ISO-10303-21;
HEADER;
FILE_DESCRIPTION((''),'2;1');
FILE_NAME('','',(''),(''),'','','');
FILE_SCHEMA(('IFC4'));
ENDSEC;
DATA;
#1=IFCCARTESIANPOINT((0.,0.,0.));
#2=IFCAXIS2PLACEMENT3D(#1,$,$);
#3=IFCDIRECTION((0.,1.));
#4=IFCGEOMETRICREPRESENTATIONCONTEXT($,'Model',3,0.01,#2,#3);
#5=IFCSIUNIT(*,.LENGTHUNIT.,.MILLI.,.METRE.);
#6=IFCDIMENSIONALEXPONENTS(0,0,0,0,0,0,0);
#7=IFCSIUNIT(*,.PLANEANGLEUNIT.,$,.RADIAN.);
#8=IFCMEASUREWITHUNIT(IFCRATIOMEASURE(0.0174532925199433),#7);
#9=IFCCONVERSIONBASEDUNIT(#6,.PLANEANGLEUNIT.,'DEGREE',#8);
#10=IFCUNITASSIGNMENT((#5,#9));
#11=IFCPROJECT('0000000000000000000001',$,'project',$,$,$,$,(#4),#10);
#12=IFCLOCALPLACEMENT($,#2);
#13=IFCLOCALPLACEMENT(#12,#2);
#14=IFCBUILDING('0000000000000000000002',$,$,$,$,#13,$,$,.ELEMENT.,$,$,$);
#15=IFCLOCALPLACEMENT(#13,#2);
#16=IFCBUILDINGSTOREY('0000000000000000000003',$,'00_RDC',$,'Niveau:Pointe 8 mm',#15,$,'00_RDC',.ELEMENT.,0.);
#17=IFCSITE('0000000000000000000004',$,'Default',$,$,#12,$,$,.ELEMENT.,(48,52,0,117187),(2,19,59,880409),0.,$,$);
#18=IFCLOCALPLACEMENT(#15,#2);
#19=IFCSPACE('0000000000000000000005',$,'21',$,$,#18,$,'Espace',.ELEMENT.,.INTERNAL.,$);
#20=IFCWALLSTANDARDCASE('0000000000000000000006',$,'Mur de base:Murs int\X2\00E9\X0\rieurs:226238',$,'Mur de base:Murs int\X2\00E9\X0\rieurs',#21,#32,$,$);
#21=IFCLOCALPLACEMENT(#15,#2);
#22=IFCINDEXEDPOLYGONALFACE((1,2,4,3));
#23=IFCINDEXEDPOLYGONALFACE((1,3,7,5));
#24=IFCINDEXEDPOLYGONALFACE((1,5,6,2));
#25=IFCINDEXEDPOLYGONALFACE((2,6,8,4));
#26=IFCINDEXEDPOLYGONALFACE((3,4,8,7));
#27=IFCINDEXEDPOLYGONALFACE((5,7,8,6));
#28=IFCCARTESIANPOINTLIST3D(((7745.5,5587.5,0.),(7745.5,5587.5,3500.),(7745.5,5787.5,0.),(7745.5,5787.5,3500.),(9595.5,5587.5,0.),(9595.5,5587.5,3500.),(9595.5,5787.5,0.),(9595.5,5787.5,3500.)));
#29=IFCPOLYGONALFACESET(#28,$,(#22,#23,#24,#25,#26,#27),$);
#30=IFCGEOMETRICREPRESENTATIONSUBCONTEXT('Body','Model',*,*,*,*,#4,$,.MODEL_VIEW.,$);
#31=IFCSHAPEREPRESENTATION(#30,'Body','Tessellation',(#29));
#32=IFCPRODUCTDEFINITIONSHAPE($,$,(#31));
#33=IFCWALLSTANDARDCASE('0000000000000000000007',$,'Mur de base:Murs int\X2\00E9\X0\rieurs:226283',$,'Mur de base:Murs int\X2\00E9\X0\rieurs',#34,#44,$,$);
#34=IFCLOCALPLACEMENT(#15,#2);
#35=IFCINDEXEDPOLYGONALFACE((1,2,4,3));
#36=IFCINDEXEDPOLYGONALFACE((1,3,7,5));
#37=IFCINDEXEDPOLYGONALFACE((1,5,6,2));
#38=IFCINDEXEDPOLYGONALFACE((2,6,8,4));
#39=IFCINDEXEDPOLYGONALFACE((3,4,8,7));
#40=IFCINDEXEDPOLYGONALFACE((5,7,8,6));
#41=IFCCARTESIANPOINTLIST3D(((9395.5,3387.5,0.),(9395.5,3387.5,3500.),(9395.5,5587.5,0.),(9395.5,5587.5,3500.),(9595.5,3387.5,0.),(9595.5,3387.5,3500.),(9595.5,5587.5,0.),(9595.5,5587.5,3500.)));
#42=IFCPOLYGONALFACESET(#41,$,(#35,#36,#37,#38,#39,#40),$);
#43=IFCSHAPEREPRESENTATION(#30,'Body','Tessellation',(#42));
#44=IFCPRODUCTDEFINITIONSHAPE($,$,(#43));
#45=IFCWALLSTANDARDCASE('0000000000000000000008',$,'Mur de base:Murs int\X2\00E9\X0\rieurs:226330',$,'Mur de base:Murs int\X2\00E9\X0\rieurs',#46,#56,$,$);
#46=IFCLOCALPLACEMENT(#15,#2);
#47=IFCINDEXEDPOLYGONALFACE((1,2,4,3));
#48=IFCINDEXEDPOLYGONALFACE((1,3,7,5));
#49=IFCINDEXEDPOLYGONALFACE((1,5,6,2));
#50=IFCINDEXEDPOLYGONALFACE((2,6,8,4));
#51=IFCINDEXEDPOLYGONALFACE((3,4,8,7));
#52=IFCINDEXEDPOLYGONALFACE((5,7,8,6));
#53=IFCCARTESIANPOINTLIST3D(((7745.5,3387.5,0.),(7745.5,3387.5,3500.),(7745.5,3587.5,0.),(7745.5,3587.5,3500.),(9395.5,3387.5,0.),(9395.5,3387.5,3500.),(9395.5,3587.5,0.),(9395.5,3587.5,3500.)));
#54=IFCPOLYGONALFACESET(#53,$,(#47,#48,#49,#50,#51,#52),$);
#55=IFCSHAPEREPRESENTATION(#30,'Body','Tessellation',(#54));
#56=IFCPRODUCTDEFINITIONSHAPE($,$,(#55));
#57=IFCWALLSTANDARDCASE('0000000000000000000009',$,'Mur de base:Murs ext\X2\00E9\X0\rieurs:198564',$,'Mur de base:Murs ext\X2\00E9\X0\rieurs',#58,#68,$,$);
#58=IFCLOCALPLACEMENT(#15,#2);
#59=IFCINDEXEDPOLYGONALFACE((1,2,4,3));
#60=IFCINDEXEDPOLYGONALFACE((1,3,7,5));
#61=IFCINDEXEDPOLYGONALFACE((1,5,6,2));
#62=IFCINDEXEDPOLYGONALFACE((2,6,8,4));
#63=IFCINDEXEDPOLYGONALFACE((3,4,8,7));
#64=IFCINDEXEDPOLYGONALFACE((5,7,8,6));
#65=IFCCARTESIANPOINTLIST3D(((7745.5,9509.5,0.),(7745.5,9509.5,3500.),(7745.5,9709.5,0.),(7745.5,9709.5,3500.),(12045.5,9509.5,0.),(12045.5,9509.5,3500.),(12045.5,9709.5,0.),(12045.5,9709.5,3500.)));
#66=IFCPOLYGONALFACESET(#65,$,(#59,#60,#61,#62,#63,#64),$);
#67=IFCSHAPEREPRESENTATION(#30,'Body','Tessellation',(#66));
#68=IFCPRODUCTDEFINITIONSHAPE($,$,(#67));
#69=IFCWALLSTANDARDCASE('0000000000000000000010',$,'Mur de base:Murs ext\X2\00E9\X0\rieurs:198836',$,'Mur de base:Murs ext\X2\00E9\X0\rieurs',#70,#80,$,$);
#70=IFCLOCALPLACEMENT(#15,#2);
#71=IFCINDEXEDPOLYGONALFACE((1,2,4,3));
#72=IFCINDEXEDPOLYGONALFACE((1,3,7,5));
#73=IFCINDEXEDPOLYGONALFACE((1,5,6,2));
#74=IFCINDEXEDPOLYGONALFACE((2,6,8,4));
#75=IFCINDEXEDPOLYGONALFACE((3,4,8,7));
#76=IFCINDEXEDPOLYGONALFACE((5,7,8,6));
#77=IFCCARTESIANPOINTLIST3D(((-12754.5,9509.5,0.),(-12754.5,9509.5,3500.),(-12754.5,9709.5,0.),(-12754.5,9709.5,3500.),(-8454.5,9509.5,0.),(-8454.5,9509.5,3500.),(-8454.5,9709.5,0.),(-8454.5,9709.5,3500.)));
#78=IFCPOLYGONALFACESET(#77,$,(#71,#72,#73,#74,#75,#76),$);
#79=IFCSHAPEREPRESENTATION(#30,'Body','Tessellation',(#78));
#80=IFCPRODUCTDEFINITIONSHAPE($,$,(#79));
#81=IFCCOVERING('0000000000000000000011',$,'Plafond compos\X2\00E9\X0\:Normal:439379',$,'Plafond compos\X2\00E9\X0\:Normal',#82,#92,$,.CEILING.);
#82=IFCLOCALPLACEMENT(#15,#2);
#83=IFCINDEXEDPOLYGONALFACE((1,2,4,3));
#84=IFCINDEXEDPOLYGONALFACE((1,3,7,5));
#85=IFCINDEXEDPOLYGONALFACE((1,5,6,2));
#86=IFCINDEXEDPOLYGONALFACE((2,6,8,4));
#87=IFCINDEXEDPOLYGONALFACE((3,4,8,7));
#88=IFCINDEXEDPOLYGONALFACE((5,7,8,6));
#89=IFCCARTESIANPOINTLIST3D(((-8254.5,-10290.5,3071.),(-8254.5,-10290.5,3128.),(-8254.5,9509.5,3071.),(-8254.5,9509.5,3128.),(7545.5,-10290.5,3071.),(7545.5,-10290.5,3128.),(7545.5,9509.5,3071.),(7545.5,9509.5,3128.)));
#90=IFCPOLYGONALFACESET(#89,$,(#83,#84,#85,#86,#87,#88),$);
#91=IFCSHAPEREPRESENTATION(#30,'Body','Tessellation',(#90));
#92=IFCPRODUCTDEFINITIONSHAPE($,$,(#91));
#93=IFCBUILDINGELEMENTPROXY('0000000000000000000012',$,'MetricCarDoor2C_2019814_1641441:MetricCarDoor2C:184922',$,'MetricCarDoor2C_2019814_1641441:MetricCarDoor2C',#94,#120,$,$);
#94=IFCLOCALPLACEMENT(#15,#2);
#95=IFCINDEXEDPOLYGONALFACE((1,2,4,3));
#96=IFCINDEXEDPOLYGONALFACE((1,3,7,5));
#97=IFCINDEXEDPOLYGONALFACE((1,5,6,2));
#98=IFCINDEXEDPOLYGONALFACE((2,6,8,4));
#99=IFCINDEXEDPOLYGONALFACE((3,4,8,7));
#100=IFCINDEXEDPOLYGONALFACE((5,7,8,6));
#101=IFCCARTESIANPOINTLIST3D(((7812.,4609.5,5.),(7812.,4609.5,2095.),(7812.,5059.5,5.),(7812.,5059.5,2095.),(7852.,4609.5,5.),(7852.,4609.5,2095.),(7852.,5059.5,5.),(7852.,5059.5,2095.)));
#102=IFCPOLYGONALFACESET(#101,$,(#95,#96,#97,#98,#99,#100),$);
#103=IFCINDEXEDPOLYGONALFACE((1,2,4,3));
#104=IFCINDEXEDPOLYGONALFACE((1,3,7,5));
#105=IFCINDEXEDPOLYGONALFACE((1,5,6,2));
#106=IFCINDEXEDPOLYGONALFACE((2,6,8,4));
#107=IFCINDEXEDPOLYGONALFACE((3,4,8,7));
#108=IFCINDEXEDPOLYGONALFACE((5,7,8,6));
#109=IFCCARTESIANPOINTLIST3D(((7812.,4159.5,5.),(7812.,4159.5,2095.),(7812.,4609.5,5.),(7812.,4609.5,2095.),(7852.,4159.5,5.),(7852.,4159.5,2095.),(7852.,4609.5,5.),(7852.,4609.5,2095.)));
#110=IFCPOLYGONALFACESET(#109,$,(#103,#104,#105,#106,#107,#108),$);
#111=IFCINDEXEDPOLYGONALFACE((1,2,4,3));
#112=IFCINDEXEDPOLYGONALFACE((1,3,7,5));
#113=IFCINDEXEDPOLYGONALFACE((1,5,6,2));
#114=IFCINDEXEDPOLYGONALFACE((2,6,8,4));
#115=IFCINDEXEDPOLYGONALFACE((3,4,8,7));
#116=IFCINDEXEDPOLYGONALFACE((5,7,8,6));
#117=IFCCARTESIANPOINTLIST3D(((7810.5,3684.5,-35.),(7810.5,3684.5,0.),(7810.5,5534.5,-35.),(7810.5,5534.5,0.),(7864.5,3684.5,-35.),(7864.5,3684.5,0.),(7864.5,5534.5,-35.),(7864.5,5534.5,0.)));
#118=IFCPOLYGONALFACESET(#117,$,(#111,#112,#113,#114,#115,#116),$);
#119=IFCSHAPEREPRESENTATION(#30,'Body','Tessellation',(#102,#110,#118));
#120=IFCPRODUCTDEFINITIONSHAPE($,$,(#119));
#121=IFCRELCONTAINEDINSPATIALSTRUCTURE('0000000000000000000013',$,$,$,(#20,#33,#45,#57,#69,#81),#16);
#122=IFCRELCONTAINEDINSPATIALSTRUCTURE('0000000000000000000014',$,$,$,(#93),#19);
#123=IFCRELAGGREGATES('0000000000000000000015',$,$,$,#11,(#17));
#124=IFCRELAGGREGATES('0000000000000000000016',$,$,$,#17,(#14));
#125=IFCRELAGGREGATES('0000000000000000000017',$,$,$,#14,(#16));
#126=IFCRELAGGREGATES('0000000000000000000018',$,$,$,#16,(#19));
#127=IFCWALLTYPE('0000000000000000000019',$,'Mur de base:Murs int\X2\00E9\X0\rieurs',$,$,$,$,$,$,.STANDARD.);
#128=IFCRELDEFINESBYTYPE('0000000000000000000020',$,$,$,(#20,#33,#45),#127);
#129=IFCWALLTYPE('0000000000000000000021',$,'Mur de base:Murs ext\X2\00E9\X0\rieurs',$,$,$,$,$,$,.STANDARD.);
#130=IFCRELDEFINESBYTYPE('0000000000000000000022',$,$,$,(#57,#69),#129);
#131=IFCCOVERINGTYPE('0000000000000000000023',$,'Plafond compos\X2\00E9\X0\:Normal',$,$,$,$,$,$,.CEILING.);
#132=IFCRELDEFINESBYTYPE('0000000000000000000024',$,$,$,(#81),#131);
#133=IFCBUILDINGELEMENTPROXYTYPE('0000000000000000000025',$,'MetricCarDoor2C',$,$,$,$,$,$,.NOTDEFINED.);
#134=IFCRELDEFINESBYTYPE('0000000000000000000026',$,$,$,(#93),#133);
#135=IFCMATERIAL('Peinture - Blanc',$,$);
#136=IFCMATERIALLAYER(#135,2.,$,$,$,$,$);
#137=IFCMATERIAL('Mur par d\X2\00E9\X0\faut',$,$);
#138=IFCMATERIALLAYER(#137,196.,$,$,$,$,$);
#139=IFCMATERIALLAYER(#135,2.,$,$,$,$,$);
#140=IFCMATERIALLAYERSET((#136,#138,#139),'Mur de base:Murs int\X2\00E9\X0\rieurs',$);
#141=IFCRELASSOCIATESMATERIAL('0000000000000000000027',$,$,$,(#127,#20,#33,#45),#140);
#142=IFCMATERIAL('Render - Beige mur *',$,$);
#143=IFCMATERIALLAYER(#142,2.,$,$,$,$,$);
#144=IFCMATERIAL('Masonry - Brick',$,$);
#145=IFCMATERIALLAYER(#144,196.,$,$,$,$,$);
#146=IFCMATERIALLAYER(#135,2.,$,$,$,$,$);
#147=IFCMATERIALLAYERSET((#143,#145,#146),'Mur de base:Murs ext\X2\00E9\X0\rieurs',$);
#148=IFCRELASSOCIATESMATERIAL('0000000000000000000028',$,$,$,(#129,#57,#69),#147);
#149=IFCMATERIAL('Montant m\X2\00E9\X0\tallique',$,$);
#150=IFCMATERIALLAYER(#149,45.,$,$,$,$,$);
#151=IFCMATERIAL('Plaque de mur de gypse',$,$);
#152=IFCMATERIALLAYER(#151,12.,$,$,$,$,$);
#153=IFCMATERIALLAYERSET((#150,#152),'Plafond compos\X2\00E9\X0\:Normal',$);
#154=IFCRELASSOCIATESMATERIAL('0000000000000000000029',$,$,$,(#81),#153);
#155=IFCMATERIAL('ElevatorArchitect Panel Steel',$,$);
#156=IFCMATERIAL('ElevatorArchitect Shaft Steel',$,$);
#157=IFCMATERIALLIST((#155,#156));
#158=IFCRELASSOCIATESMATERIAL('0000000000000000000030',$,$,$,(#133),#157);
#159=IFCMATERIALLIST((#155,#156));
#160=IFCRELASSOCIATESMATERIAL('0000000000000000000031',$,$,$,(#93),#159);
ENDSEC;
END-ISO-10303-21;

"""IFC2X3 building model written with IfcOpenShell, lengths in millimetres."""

from ifc_helpers import new_model, entity, si_unit, converted_unit, direction, frame, frame_2d, origin, origin_2d_with_axis, place, context, subcontext, project, spatial, rectangle, extrude, source, transform, mapped, material, material_list, layer, layer_set, layer_usage, type_object, type_shapes, element, save


model = new_model("IFC2X3")

# Units and contexts
model_context = context("Model", 3, precision=0.01, world=origin(), true_north=direction((0.0, 1.0)))
body_context = subcontext(model_context, "Body", "Model", "MODEL_VIEW")
ifc_project = project(units=[si_unit("LENGTHUNIT", "METRE", prefix="MILLI"), converted_unit("PLANEANGLEUNIT", "DEGREE", entity("IfcRatioMeasure", 0.0174532925199433), si_unit("PLANEANGLEUNIT", "RADIAN"), dimensions=[0, 0, 0, 0, 0, 0, 0])], contexts=[model_context])

# Site, building, storey
site_placement = place(None, origin())
site = spatial("IfcSite", under=ifc_project, at=site_placement, Name="Default", CompositionType="ELEMENT", RefLatitude=(48, 52, 0, 117187), RefLongitude=(2, 19, 59, 880409), RefElevation=0.0)
building_placement = place(site_placement, origin())
building = spatial("IfcBuilding", under=site, at=building_placement, CompositionType="ELEMENT")
storey_placement = place(building_placement, origin())
storey = spatial("IfcBuildingStorey", under=building, at=storey_placement, Name="00_RDC", ObjectType="Niveau:Pointe 8 mm", LongName="00_RDC", CompositionType="ELEMENT", Elevation=0.0)

# Shared definitions
ifc_material_1 = material(Name="Peinture - Blanc")
ifc_layer_1 = layer(ifc_material_1, 2.0)
ifc_material_2 = material(Name="Mur par défaut")
ifc_layer_2 = layer(ifc_material_2, 196.0)
ifc_layer_3 = layer(ifc_material_1, 2.0)
ifc_layer_set_1 = layer_set([ifc_layer_1, ifc_layer_2, ifc_layer_3], Name="Mur de base:Murs intérieurs")
wall_type_1 = type_object("IfcWallType", Name="Mur de base:Murs intérieurs", PredefinedType="STANDARD", material=ifc_layer_set_1)

# Walls
ifc_layer_usage_1 = layer_usage(ifc_layer_set_1, "AXIS2", "NEGATIVE", 100.0)
wall_1_placement = place(storey_placement, frame((7745.5, 5687.5, 0.0)))
element("IfcWallStandardCase", 1, at=wall_1_placement, inside=storey, type_object=wall_type_1, material=ifc_layer_usage_1, Name="Mur de base:Murs intérieurs:226238", ObjectType="Mur de base:Murs intérieurs", context=body_context, shape_type="SweptSolid", body=[
    extrude(rectangle(XDim=1850.0, YDim=200.0, at=frame_2d((925.0, 0.0), x_axis=(-1.0, 0.0))), origin(), (0.0, 0.0, 1.0), 3500.0),
])
ifc_layer_usage_2 = layer_usage(ifc_layer_set_1, "AXIS2", "NEGATIVE", 100.0)
wall_2_placement = place(storey_placement, frame((9495.5, 5587.5, 0.0), z_axis=(0.0, 0.0, 1.0), x_axis=(0.0, -1.0, 0.0)))
element("IfcWallStandardCase", 2, at=wall_2_placement, inside=storey, type_object=wall_type_1, material=ifc_layer_usage_2, Name="Mur de base:Murs intérieurs:226283", ObjectType="Mur de base:Murs intérieurs", context=body_context, shape_type="SweptSolid", body=[
    extrude(rectangle(XDim=2200.0, YDim=200.0, at=frame_2d((1100.0, 0.0), x_axis=(-1.0, 0.0))), origin(), (0.0, 0.0, 1.0), 3500.0),
])
ifc_layer_usage_3 = layer_usage(ifc_layer_set_1, "AXIS2", "NEGATIVE", 100.0)
wall_3_placement = place(storey_placement, frame((9395.5, 3487.5, 0.0), z_axis=(0.0, 0.0, 1.0), x_axis=(-1.0, 0.0, 0.0)))
element("IfcWallStandardCase", 3, at=wall_3_placement, inside=storey, type_object=wall_type_1, material=ifc_layer_usage_3, Name="Mur de base:Murs intérieurs:226330", ObjectType="Mur de base:Murs intérieurs", context=body_context, shape_type="SweptSolid", body=[
    extrude(rectangle(XDim=1650.0, YDim=200.0, at=frame_2d((825.0, 0.0), x_axis=(-1.0, 0.0))), origin(), (0.0, 0.0, 1.0), 3500.0),
])
ifc_material_3 = material(Name="Render - Beige mur *")
ifc_layer_4 = layer(ifc_material_3, 2.0)
ifc_material_4 = material(Name="Masonry - Brick")
ifc_layer_5 = layer(ifc_material_4, 196.0)
ifc_layer_6 = layer(ifc_material_1, 2.0)
ifc_layer_set_2 = layer_set([ifc_layer_4, ifc_layer_5, ifc_layer_6], Name="Mur de base:Murs extérieurs")
ifc_layer_usage_4 = layer_usage(ifc_layer_set_2, "AXIS2", "NEGATIVE", 100.0)
wall_type_2 = type_object("IfcWallType", Name="Mur de base:Murs extérieurs", PredefinedType="STANDARD", material=ifc_layer_set_2)
wall_4_placement = place(storey_placement, frame((7745.5, 9609.5, 0.0)))
element("IfcWallStandardCase", 4, at=wall_4_placement, inside=storey, type_object=wall_type_2, material=ifc_layer_usage_4, Name="Mur de base:Murs extérieurs:198564", ObjectType="Mur de base:Murs extérieurs", context=body_context, shape_type="SweptSolid", body=[
    extrude(rectangle(XDim=4300.0, YDim=200.0, at=frame_2d((2150.0, 0.0), x_axis=(-1.0, 0.0))), origin(), (0.0, 0.0, 1.0), 3500.0),
])
ifc_layer_usage_5 = layer_usage(ifc_layer_set_2, "AXIS2", "POSITIVE", -100.0)
wall_5_placement = place(storey_placement, frame((-8454.5, 9609.5, 0.0), z_axis=(0.0, 0.0, 1.0), x_axis=(-1.0, 0.0, 0.0)))
element("IfcWallStandardCase", 5, at=wall_5_placement, inside=storey, type_object=wall_type_2, material=ifc_layer_usage_5, Name="Mur de base:Murs extérieurs:198836", ObjectType="Mur de base:Murs extérieurs", context=body_context, shape_type="SweptSolid", body=[
    extrude(rectangle(XDim=4300.0, YDim=200.0, at=frame_2d((2150.0, 0.0), x_axis=(-1.0, 0.0))), origin(), (0.0, 0.0, 1.0), 3500.0),
])

# Covering
ifc_material_5 = material(Name="Montant métallique")
ifc_layer_7 = layer(ifc_material_5, 45.0)
ifc_material_6 = material(Name="Plaque de mur de gypse")
ifc_layer_8 = layer(ifc_material_6, 12.0)
ifc_layer_set_3 = layer_set([ifc_layer_7, ifc_layer_8], Name="Plafond composé:Normal")
ifc_layer_usage_6 = layer_usage(ifc_layer_set_3, "AXIS3", "POSITIVE", 0.0)
covering_type = type_object("IfcCoveringType", Name="Plafond composé:Normal", PredefinedType="CEILING")
covering_placement = place(storey_placement, origin())
element("IfcCovering", 6, at=covering_placement, inside=storey, type_object=covering_type, material=ifc_layer_usage_6, Name="Plafond composé:Normal:439379", ObjectType="Plafond composé:Normal", PredefinedType="CEILING", context=body_context, shape_type="SweptSolid", body=[
    extrude(rectangle(XDim=15800.0, YDim=19800.0, at=frame_2d((0.0, 0.0), x_axis=(1.0, 0.0))), frame((-354.5, -390.5, 3071.0), z_axis=(0.0, 0.0, 1.0), x_axis=(-1.0, 0.0, 0.0)), (0.0, 0.0, 1.0), 57.0),
])

# Shared definitions
space_1_placement = place(storey_placement, origin())
space_1 = spatial("IfcSpace", under=storey, at=space_1_placement, Name="21", LongName="Espace", CompositionType="ELEMENT", InteriorOrExteriorSpace="INTERNAL")

# Building element proxy
ifc_material_7 = material(Name="ElevatorArchitect Panel Steel")
ifc_material_8 = material(Name="ElevatorArchitect Shaft Steel")
ifc_material_list_1 = material_list([ifc_material_7, ifc_material_8])
ifc_material_list_2 = material_list([ifc_material_7, ifc_material_8])
building_element_proxy_type_1 = type_object("IfcBuildingElementProxyType", Name="MetricCarDoor2C", PredefinedType="NOTDEFINED", material=ifc_material_list_2)
shared_shape_1 = source(origin(), body_context, "Body", "SweptSolid", [
    extrude(rectangle(XDim=450.0, YDim=40.0, at=origin_2d_with_axis()), frame((-225.0, -23.5, 5.0)), (0.0, 0.0, 1.0), 2090.0),
    extrude(rectangle(XDim=450.0, YDim=40.0, at=origin_2d_with_axis()), frame((225.0, -23.5, 5.0)), (0.0, 0.0, 1.0), 2090.0),
    extrude(rectangle(XDim=1850.0, YDim=54.0, at=origin_2d_with_axis()), frame((0.0, -18.0, -35.0), z_axis=(0.0, 0.0, 1.0), x_axis=(-1.0, 0.0, 0.0)), (0.0, 0.0, 1.0), 35.0),
])
type_shapes(building_element_proxy_type_1, [shared_shape_1])
proxy_1_placement = place(space_1_placement, frame((7855.5, 4609.5, 0.0), z_axis=(0.0, 0.0, 1.0), x_axis=(0.0, -1.0, 0.0)))
element("IfcBuildingElementProxy", 7, at=proxy_1_placement, inside=space_1, type_object=building_element_proxy_type_1, material=ifc_material_list_1, Name="MetricCarDoor2C_2019814_1641441:MetricCarDoor2C:184922", ObjectType="MetricCarDoor2C_2019814_1641441:MetricCarDoor2C", context=body_context, shape_type="MappedRepresentation", body=[
    mapped(shared_shape_1, transform((0.0, 0.0, 0.0), scale=1.0)),
])

save(model, "model.ifc")
